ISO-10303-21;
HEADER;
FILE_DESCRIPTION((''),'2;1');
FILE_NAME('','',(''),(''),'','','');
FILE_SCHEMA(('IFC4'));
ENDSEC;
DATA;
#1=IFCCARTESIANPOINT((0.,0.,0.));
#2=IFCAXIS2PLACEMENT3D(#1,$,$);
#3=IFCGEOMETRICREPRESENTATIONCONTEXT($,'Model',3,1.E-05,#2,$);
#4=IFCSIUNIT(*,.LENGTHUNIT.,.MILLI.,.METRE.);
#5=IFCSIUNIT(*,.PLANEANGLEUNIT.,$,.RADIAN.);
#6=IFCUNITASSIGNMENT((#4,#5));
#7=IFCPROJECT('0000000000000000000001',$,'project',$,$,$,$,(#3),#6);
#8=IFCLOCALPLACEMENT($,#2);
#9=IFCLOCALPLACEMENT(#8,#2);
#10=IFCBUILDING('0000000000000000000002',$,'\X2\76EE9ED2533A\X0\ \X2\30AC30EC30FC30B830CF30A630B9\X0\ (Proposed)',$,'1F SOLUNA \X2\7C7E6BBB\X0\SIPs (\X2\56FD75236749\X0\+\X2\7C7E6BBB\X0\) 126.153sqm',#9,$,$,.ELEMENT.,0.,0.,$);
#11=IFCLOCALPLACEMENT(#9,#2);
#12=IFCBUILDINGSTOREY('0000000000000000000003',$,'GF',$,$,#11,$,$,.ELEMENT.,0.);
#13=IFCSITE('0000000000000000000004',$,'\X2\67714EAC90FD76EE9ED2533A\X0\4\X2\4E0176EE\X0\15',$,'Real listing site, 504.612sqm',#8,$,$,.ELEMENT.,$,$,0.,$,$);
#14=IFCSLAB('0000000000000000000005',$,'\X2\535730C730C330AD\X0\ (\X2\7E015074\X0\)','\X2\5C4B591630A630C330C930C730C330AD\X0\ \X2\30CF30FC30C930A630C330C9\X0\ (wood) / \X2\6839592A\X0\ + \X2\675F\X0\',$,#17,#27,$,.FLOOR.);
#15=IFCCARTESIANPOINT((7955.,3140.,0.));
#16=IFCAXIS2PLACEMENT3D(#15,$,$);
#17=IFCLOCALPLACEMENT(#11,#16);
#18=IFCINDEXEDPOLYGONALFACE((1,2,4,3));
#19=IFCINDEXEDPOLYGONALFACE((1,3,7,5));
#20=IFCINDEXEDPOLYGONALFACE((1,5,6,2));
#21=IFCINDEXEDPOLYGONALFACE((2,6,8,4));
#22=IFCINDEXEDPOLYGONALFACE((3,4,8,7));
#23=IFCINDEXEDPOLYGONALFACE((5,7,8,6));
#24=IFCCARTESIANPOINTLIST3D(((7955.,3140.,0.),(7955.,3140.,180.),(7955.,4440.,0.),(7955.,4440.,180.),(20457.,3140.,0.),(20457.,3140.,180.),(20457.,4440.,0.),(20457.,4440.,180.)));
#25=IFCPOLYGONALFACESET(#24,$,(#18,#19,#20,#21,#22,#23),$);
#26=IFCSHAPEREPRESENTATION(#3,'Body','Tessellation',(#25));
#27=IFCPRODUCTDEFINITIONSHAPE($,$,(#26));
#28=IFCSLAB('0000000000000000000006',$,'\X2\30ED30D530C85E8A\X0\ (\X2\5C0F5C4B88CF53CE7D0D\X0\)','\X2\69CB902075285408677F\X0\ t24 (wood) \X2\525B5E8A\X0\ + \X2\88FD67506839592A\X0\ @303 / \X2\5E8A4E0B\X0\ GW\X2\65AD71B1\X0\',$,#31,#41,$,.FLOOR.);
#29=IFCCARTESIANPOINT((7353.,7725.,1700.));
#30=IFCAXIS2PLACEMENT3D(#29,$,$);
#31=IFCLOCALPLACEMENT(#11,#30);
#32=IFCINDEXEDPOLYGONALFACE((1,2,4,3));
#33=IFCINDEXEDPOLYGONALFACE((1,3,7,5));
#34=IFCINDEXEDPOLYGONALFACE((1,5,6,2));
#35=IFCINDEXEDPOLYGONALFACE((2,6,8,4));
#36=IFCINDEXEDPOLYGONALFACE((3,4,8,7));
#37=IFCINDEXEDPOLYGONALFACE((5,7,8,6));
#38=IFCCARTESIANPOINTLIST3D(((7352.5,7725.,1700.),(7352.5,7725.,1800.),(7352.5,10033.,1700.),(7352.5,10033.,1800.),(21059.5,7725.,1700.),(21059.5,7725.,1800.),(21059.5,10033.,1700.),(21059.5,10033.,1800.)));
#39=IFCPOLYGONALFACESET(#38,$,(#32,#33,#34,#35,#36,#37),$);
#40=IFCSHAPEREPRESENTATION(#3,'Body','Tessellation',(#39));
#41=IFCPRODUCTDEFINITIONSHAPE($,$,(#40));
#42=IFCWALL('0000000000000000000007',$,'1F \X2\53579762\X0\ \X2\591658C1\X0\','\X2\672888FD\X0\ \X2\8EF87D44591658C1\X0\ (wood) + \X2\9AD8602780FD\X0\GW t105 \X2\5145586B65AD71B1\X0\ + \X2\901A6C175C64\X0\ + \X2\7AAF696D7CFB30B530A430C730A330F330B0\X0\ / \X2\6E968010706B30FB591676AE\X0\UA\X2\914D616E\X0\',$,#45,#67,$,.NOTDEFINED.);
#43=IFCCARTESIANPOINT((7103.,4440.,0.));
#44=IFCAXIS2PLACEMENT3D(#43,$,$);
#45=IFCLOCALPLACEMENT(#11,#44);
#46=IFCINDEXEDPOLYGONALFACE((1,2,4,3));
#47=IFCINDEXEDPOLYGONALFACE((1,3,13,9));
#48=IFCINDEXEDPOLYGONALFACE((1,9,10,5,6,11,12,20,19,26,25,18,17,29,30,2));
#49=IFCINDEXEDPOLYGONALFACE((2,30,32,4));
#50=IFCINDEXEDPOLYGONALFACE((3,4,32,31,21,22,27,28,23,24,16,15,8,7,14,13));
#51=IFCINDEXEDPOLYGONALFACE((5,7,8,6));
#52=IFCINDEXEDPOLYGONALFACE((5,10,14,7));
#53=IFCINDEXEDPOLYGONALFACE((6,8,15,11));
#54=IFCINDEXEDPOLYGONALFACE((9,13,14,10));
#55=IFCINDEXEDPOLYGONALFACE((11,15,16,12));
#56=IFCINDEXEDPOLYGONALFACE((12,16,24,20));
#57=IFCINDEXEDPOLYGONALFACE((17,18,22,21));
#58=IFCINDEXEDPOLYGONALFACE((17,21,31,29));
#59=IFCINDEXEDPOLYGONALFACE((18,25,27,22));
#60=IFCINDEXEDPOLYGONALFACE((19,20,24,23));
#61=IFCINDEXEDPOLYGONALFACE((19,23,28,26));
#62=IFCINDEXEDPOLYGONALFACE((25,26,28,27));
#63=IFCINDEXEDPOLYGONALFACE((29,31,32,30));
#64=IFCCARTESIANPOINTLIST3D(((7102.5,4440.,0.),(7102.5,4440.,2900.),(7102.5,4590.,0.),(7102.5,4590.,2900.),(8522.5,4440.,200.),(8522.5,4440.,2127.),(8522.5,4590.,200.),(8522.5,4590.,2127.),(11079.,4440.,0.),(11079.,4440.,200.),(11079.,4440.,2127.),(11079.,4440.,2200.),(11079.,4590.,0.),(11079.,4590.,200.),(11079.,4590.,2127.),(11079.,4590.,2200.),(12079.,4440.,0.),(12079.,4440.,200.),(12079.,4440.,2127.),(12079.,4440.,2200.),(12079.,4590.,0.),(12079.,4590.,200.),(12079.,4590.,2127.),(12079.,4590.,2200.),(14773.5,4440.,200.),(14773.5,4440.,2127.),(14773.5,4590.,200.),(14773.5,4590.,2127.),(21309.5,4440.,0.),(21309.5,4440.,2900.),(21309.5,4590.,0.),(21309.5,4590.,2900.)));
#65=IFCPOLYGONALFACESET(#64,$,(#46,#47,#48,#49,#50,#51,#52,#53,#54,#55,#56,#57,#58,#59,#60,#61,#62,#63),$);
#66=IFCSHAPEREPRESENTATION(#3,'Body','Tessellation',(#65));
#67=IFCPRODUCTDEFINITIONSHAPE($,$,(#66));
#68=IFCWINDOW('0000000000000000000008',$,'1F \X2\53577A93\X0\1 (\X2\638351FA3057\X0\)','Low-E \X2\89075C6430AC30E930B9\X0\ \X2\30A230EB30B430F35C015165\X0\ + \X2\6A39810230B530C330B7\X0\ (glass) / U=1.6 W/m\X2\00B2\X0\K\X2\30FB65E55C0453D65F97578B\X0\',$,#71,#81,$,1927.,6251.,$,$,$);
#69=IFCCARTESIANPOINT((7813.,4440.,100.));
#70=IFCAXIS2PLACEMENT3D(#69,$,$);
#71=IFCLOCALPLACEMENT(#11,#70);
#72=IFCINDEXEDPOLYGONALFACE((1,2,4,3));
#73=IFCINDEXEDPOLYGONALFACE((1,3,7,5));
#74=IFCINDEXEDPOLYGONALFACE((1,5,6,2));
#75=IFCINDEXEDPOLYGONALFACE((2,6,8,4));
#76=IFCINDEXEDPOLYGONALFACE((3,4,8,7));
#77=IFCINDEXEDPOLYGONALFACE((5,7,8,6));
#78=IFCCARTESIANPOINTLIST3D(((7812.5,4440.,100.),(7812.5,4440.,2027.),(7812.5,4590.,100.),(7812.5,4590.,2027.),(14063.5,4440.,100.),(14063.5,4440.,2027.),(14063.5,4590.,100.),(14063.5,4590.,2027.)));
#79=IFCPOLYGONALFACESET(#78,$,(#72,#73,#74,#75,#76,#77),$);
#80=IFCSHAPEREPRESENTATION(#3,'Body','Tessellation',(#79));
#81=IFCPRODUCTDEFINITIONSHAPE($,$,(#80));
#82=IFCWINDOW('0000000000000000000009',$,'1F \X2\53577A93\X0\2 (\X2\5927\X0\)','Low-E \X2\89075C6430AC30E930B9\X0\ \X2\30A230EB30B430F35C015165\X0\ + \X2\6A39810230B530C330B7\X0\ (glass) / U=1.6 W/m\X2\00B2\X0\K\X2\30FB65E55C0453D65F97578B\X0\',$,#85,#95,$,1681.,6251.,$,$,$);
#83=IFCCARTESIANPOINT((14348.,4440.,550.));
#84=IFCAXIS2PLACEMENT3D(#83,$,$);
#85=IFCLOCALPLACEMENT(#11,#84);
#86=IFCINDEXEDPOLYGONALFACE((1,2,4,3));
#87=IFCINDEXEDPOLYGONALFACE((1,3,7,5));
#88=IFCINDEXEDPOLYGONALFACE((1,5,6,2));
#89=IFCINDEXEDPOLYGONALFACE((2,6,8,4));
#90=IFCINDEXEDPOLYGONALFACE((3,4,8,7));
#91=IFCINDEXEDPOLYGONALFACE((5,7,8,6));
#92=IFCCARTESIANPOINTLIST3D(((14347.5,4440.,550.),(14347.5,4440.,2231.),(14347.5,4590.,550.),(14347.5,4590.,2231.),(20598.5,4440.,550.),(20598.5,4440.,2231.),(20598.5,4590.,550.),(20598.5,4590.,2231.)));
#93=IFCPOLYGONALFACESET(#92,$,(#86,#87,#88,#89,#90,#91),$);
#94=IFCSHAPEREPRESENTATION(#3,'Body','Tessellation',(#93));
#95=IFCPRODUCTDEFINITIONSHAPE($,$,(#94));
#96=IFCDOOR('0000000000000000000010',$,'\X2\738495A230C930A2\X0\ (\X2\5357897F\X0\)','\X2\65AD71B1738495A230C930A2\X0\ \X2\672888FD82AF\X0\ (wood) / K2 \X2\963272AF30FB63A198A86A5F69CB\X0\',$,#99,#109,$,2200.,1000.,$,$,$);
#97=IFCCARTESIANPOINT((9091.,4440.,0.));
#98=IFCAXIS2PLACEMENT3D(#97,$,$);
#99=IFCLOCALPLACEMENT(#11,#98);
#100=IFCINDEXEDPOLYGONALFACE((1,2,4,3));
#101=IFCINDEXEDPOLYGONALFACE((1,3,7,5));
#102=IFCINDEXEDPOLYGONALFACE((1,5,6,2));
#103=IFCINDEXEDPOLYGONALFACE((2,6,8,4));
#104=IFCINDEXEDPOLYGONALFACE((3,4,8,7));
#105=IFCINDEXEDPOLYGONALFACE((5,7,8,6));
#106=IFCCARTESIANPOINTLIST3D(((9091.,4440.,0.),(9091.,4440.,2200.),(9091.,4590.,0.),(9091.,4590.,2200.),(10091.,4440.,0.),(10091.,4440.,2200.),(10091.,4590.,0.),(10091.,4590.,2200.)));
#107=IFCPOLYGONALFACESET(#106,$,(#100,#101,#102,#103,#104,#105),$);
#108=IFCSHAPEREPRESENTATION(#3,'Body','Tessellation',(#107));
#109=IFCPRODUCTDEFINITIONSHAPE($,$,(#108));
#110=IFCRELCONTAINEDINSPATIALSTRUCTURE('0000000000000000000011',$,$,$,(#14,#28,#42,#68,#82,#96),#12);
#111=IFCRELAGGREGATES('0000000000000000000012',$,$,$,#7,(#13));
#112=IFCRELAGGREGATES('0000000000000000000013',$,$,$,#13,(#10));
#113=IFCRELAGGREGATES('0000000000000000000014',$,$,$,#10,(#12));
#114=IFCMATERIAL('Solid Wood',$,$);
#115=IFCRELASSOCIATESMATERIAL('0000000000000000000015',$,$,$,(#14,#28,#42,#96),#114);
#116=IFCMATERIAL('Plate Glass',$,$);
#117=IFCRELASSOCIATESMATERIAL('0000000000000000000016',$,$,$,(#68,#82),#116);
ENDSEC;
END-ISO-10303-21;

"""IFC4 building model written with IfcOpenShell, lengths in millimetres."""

from ifc_helpers import new_model, si_unit, frame, frame_2d, origin, place, context, project, spatial, rectangle, extrude, material, element, fill, save


model = new_model("IFC4")

# Units and contexts
model_context = context("Model", 3, precision=1e-05, world=origin())
ifc_project = project(units=[si_unit("LENGTHUNIT", "METRE", prefix="MILLI"), si_unit("PLANEANGLEUNIT", "RADIAN")], contexts=[model_context])

# Site, building, storey
site_placement = place(None, origin())
site = spatial("IfcSite", under=ifc_project, at=site_placement, Name="東京都目黒区4丁目15", ObjectType="Real listing site, 504.612sqm", CompositionType="ELEMENT", RefElevation=0.0)
building_placement = place(site_placement, origin())
building = spatial("IfcBuilding", under=site, at=building_placement, Name="目黒区 ガレージハウス (Proposed)", ObjectType="1F SOLUNA 籾殻SIPs (国産杉+籾殻) 126.153sqm", CompositionType="ELEMENT", ElevationOfRefHeight=0.0, ElevationOfTerrain=0.0)
storey_placement = place(building_placement, origin())
storey = spatial("IfcBuildingStorey", under=building, at=storey_placement, Name="GF", CompositionType="ELEMENT", Elevation=0.0)

# Slabs
ifc_material_1 = material(Name="Solid Wood")
slab_1_placement = place(storey_placement, frame((7955.0, 3140.0, 0.0)))
element("IfcSlab", 1, at=slab_1_placement, inside=storey, material=ifc_material_1, Name="南デッキ (縁側)", Description="屋外ウッドデッキ ハードウッド (wood) / 根太 + 束", PredefinedType="FLOOR", context=model_context, shape_type="SweptSolid", body=[
    extrude(rectangle(XDim=12502.0, YDim=1300.0, at=frame_2d((6251.0, 650.0))), frame((7955.0, 3140.0, 0.0)), (0.0, 0.0, 1.0), 180.0),
])
slab_2_placement = place(storey_placement, frame((7353.0, 7725.0, 1700.0)))
element("IfcSlab", 2, at=slab_2_placement, inside=storey, material=ifc_material_1, Name="ロフト床 (小屋裏収納)", Description="構造用合板 t24 (wood) 剛床 + 製材根太 @303 / 床下 GW断熱", PredefinedType="FLOOR", context=model_context, shape_type="SweptSolid", body=[
    extrude(rectangle(XDim=13707.0, YDim=2308.0, at=frame_2d((6853.0, 1154.0))), frame((7353.0, 7725.0, 1700.0)), (0.0, 0.0, 1.0), 100.0),
])

# Wall, openings, windows, door
wall_1_placement = place(storey_placement, frame((7103.0, 4440.0, 0.0)))
wall_1 = element("IfcWall", 3, at=wall_1_placement, inside=storey, material=ifc_material_1, Name="1F 南面 外壁", Description="木製 軸組外壁 (wood) + 高性能GW t105 充填断熱 + 通気層 + 窯業系サイディング / 準耐火・外皮UA配慮", PredefinedType="NOTDEFINED", context=model_context, shape_type="SweptSolid", body=[
    extrude(rectangle(XDim=14207.0, YDim=150.0, at=frame_2d((7103.0, 75.0))), frame((7103.0, 4440.0, 0.0)), (0.0, 0.0, 1.0), 2900.0),
])
opening_1_placement = place(storey_placement, frame((7813.0, 4440.0, 100.0)))
opening_1 = element("IfcOpeningElement", 4, at=opening_1_placement, cuts=wall_1, PredefinedType="NOTDEFINED", context=model_context, shape_type="SweptSolid", body=[
    extrude(rectangle(XDim=6251.0, YDim=150.0, at=frame_2d((3125.0, 75.0))), frame((7813.0, 4440.0, 100.0)), (0.0, 0.0, 1.0), 1927.0),
])
opening_2_placement = place(storey_placement, frame((14348.0, 4440.0, 550.0)))
opening_2 = element("IfcOpeningElement", 5, at=opening_2_placement, cuts=wall_1, PredefinedType="NOTDEFINED", context=model_context, shape_type="SweptSolid", body=[
    extrude(rectangle(XDim=6251.0, YDim=150.0, at=frame_2d((3125.0, 75.0))), frame((14348.0, 4440.0, 550.0)), (0.0, 0.0, 1.0), 1681.0),
])
opening_3_placement = place(storey_placement, frame((9091.0, 4440.0, 0.0)))
opening_3 = element("IfcOpeningElement", 6, at=opening_3_placement, cuts=wall_1, PredefinedType="NOTDEFINED", context=model_context, shape_type="SweptSolid", body=[
    extrude(rectangle(XDim=1000.0, YDim=150.0, at=frame_2d((500.0, 75.0))), frame((9091.0, 4440.0, 0.0)), (0.0, 0.0, 1.0), 2200.0),
])
ifc_material_2 = material(Name="Plate Glass")
window_1_placement = place(storey_placement, frame((7813.0, 4440.0, 100.0)))
window_1 = element("IfcWindow", 7, at=window_1_placement, inside=storey, material=ifc_material_2, Name="1F 南窓1 (掃出し)", Description="Low-E 複層ガラス アルゴン封入 + 樹脂サッシ (glass) / U=1.6 W/m²K・日射取得型", OverallHeight=1927.0, OverallWidth=6251.0, context=model_context, shape_type="SweptSolid", body=[
    extrude(rectangle(XDim=6251.0, YDim=150.0, at=frame_2d((3125.0, 75.0))), frame((7813.0, 4440.0, 100.0)), (0.0, 0.0, 1.0), 1927.0),
])
fill(opening_1, window_1)
window_2_placement = place(storey_placement, frame((14348.0, 4440.0, 550.0)))
window_2 = element("IfcWindow", 8, at=window_2_placement, inside=storey, material=ifc_material_2, Name="1F 南窓2 (大)", Description="Low-E 複層ガラス アルゴン封入 + 樹脂サッシ (glass) / U=1.6 W/m²K・日射取得型", OverallHeight=1681.0, OverallWidth=6251.0, context=model_context, shape_type="SweptSolid", body=[
    extrude(rectangle(XDim=6251.0, YDim=150.0, at=frame_2d((3125.0, 75.0))), frame((14348.0, 4440.0, 550.0)), (0.0, 0.0, 1.0), 1681.0),
])
fill(opening_2, window_2)
door_1_placement = place(storey_placement, frame((9091.0, 4440.0, 0.0)))
door_1 = element("IfcDoor", 9, at=door_1_placement, inside=storey, material=ifc_material_1, Name="玄関ドア (南西)", Description="断熱玄関ドア 木製芯 (wood) / K2 防犯・採風機構", OverallHeight=2200.0, OverallWidth=1000.0, context=model_context, shape_type="SweptSolid", body=[
    extrude(rectangle(XDim=1000.0, YDim=150.0, at=frame_2d((500.0, 75.0))), frame((9091.0, 4440.0, 0.0)), (0.0, 0.0, 1.0), 2200.0),
])
fill(opening_3, door_1)

save(model, "model.ifc")
